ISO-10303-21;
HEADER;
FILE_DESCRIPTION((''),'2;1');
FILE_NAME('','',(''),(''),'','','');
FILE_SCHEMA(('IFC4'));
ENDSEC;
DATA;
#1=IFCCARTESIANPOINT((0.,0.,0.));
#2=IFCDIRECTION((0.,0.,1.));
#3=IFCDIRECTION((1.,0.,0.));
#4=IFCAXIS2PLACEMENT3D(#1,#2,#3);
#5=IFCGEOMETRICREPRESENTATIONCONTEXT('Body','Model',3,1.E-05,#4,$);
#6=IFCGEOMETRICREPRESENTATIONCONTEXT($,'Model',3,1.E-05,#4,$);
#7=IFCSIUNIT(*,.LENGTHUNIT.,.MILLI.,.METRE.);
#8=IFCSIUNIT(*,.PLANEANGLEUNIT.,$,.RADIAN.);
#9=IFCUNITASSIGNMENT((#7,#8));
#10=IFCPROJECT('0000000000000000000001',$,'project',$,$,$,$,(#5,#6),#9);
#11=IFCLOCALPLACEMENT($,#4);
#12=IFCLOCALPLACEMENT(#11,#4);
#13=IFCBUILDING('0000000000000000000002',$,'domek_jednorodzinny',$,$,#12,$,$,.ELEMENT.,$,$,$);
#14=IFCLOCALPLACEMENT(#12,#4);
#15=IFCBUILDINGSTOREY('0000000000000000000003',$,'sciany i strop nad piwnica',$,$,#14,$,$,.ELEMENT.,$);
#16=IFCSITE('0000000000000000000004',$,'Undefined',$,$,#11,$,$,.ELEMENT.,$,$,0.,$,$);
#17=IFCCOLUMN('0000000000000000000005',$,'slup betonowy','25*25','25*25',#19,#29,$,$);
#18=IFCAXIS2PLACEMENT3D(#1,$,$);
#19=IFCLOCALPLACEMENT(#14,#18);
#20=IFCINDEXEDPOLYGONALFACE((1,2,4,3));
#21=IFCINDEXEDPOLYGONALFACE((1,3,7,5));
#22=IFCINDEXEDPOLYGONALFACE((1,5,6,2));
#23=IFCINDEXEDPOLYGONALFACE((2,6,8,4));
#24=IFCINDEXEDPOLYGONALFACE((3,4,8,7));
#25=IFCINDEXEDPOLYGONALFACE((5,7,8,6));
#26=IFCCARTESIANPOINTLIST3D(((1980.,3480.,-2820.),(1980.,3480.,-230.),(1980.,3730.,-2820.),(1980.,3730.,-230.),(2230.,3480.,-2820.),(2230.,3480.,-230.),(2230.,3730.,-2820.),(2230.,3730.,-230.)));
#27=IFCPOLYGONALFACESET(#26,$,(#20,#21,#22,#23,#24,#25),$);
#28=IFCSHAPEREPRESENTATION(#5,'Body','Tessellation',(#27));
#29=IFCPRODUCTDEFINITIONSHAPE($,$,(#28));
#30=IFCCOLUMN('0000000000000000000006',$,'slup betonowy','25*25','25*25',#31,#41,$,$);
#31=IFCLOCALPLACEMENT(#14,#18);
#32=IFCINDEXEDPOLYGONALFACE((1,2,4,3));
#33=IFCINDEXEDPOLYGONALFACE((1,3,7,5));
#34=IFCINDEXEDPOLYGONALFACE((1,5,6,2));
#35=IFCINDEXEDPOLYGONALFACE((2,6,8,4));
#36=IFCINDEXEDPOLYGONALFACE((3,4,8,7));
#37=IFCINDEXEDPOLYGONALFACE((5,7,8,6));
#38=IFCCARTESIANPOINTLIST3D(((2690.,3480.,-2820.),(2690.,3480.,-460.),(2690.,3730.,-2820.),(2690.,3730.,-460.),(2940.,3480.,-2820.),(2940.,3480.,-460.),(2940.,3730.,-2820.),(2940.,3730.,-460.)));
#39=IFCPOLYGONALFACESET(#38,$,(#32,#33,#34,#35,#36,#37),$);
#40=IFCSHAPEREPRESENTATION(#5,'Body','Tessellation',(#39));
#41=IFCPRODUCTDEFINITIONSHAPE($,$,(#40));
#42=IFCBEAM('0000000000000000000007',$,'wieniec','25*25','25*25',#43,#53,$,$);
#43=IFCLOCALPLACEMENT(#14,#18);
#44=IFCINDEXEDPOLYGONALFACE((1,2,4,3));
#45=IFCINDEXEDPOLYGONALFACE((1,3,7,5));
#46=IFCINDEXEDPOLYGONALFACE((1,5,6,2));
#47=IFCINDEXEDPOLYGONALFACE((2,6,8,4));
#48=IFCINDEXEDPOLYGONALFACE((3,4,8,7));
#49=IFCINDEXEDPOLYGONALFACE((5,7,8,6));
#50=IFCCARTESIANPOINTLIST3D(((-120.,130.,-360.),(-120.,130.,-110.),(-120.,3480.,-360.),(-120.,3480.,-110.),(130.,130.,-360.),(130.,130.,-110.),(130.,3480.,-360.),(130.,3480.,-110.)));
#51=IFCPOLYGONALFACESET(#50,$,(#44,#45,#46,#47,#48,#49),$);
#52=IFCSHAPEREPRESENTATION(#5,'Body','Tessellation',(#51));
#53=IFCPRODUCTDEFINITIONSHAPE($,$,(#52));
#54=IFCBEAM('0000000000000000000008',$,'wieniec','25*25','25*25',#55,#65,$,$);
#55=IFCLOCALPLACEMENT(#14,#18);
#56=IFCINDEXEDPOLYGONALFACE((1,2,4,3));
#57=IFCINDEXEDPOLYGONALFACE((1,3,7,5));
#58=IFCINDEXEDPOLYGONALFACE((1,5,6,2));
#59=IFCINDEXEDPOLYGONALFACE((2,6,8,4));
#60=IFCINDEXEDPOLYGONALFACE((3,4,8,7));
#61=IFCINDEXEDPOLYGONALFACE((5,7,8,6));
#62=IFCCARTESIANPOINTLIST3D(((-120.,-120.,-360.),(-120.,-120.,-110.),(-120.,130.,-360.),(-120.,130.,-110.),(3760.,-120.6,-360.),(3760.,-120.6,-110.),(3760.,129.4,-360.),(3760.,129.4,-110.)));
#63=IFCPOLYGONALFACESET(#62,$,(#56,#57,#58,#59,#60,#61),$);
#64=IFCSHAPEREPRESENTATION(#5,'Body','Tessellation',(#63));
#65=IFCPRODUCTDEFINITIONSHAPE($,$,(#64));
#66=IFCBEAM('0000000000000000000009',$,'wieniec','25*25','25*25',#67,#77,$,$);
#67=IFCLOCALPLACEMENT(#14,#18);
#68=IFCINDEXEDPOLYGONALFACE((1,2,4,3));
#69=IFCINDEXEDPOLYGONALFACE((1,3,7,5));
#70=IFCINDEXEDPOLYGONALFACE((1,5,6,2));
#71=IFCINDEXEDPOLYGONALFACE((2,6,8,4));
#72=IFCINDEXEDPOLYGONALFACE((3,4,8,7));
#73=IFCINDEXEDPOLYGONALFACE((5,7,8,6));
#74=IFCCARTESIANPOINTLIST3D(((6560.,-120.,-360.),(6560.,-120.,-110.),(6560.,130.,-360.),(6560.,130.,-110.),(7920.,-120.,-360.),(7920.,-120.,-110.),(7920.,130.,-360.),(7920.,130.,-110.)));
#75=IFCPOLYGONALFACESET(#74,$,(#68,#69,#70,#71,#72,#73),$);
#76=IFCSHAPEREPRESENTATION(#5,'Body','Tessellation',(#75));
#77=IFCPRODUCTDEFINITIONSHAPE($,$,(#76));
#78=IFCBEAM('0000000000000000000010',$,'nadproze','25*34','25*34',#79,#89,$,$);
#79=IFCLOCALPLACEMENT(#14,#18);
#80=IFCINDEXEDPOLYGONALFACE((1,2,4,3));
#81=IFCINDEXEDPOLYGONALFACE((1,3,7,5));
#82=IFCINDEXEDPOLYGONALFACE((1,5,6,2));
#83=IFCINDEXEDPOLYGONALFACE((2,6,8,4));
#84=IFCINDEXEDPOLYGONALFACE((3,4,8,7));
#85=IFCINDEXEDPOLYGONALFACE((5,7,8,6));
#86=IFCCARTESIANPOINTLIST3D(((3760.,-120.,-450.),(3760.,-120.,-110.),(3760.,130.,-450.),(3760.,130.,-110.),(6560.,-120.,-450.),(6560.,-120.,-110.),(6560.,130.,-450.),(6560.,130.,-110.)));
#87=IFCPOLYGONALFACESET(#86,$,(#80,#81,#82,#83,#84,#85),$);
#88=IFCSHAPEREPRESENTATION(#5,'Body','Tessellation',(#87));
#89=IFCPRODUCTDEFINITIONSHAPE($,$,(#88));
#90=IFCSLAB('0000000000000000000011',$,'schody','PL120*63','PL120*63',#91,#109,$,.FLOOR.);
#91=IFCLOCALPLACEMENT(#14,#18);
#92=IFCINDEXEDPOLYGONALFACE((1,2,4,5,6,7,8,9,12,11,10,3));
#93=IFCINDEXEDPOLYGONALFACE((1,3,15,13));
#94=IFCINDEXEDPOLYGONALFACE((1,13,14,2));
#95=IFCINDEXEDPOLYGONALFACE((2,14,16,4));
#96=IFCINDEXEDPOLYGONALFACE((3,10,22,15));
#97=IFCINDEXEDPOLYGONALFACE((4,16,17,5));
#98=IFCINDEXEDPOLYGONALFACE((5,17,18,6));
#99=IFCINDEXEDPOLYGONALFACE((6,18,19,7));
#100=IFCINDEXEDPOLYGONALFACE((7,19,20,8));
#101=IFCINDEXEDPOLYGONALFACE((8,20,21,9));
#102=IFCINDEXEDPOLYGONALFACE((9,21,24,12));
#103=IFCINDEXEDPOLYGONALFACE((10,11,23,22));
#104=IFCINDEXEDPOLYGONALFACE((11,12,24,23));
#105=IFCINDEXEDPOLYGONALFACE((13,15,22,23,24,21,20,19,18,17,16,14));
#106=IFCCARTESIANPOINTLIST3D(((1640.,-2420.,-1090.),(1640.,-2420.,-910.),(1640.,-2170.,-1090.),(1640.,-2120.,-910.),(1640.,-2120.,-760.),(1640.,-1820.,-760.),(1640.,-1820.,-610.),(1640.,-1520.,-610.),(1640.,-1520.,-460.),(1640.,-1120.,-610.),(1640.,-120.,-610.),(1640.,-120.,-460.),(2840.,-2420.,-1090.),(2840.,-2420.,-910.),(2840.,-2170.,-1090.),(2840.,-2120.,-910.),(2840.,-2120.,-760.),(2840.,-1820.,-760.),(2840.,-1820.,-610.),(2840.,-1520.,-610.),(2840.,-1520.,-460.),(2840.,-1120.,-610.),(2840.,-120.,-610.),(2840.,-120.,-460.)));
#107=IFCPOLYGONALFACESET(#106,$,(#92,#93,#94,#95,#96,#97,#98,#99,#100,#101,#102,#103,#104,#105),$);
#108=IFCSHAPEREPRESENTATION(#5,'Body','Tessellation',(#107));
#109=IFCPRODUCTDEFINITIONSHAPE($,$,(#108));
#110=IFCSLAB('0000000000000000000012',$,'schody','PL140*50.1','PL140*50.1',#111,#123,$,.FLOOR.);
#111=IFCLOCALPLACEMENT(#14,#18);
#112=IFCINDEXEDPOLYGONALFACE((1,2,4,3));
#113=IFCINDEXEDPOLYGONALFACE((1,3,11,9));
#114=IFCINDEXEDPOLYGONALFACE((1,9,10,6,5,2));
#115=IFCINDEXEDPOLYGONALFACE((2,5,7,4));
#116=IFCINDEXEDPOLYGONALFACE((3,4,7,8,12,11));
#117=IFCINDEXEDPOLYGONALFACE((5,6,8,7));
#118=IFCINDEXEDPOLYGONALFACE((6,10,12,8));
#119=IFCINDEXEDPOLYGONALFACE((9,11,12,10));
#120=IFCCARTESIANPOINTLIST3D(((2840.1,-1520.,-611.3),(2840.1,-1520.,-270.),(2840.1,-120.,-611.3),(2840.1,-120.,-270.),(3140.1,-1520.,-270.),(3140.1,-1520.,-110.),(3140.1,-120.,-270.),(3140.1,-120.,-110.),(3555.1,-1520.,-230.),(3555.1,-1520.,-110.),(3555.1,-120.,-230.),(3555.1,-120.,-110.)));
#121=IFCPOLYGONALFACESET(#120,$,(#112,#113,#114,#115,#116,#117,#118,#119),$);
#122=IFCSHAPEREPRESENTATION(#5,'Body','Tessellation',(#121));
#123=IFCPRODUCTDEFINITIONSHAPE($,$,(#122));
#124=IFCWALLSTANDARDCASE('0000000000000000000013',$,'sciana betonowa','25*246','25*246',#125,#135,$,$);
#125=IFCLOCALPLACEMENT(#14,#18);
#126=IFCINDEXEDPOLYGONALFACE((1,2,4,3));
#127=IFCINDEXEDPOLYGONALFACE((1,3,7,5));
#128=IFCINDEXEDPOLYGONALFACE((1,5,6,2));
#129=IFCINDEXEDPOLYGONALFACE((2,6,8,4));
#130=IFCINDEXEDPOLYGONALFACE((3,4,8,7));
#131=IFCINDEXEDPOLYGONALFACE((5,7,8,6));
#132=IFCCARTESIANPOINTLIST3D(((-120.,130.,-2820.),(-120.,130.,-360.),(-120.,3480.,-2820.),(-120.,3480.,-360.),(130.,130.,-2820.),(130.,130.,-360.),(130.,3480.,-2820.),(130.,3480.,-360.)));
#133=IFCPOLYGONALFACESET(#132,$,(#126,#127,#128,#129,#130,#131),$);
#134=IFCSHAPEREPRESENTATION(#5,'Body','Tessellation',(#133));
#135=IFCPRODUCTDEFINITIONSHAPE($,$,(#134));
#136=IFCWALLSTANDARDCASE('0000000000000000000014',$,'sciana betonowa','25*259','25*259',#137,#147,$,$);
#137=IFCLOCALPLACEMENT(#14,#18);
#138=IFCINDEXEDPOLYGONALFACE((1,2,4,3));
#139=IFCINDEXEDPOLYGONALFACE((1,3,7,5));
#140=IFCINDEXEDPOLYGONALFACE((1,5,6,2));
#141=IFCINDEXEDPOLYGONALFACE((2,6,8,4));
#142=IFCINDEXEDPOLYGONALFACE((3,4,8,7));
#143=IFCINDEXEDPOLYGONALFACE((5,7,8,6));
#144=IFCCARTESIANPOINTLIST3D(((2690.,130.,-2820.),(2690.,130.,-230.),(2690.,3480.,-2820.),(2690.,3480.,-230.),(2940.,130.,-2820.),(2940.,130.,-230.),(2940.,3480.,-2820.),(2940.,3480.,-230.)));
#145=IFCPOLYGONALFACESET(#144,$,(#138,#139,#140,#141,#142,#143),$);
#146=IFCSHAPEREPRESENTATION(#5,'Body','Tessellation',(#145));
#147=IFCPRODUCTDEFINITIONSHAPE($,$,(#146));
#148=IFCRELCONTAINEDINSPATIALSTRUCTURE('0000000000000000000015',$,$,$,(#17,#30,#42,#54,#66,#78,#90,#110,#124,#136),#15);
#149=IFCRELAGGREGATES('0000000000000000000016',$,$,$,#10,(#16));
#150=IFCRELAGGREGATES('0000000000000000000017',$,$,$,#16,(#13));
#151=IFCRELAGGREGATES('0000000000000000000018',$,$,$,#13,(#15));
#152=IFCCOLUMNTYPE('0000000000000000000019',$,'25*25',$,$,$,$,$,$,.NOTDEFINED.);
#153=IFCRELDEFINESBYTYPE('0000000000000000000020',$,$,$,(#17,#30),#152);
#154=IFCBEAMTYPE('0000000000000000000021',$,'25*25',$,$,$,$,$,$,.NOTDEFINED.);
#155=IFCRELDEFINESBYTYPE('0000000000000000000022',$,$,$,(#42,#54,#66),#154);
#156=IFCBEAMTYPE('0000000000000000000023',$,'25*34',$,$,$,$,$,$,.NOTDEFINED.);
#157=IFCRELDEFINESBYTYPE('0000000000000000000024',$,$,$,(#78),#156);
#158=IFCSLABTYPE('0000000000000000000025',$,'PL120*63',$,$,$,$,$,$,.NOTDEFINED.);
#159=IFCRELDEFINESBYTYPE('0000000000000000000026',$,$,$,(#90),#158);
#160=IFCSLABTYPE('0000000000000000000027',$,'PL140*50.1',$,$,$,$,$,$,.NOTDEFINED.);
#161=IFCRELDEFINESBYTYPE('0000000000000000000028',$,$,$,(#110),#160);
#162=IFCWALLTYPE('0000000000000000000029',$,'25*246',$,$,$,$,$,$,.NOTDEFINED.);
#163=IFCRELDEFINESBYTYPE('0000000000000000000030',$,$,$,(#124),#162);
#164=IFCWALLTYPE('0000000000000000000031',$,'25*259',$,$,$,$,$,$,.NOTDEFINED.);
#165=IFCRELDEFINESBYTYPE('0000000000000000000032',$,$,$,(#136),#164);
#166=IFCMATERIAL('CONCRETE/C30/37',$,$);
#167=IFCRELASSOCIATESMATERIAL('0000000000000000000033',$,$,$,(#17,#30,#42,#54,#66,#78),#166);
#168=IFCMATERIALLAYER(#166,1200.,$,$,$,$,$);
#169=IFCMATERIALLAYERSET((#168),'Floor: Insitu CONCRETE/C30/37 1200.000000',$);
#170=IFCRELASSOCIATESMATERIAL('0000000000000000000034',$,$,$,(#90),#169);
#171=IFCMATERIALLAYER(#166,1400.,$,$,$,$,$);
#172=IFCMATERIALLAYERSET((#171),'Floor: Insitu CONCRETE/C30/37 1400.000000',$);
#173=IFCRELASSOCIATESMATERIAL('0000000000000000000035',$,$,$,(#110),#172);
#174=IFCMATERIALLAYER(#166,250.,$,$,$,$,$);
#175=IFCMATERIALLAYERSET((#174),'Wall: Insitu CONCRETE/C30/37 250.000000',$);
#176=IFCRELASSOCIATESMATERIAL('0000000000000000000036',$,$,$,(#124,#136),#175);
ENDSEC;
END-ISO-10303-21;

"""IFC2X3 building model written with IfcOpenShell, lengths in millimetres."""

from ifc_helpers import new_model, si_unit, frame, frame_2d, origin_with_axes, origin_2d_with_axis, place, context, project, spatial, polyline, rectangle, outline, extrude, material, layer, layer_set, layer_usage, type_object, element, save


model = new_model("IFC2X3")

# Units and contexts
model_context_1 = context("Model", 3, precision=1e-05, world=origin_with_axes(), identifier="Body")
model_context_2 = context("Model", 3, precision=1e-05, world=origin_with_axes())
ifc_project = project(units=[si_unit("LENGTHUNIT", "METRE", prefix="MILLI"), si_unit("PLANEANGLEUNIT", "RADIAN")], contexts=[model_context_1, model_context_2])

# Site, building, storey
site_placement = place(None, origin_with_axes())
site = spatial("IfcSite", under=ifc_project, at=site_placement, Name="Undefined", CompositionType="ELEMENT", RefElevation=0.0)
building_placement = place(site_placement, origin_with_axes())
building = spatial("IfcBuilding", under=site, at=building_placement, Name="domek_jednorodzinny", CompositionType="ELEMENT")
storey_placement = place(building_placement, origin_with_axes())
storey = spatial("IfcBuildingStorey", under=building, at=storey_placement, Name="sciany i strop nad piwnica", CompositionType="ELEMENT")

# Columns
ifc_material_1 = material(Name="CONCRETE/C30/37")
column_type = type_object("IfcColumnType", Name="25*25", PredefinedType="NOTDEFINED")
column_1_placement = place(storey_placement, frame((2105.0, 3605.0, -2820.0), z_axis=(0.0, 0.0, 1.0), x_axis=(1.0, 0.0, 0.0)))
element("IfcColumn", 1, at=column_1_placement, inside=storey, type_object=column_type, material=ifc_material_1, Name="slup betonowy", Description="25*25", ObjectType="25*25", context=model_context_1, shape_type="SweptSolid", body=[
    extrude(rectangle(XDim=250.0, YDim=250.0, at=origin_2d_with_axis()), frame((0.0, 0.0, 2590.0), z_axis=(0.000001, 0.000001, -1.0), x_axis=(-1.0, 0.0, 0.0)), (0.0, 0.0, 1.0), 2590.0),
])
column_2_placement = place(storey_placement, frame((2815.0, 3605.0, -2820.0), z_axis=(0.0, 0.0, 1.0), x_axis=(1.0, 0.0, 0.0)))
element("IfcColumn", 2, at=column_2_placement, inside=storey, type_object=column_type, material=ifc_material_1, Name="slup betonowy", Description="25*25", ObjectType="25*25", context=model_context_1, shape_type="SweptSolid", body=[
    extrude(rectangle(XDim=250.0, YDim=250.0, at=origin_2d_with_axis()), frame((0.0, 0.0, 2360.0), z_axis=(0.000001, 0.000001, -1.0), x_axis=(-1.0, 0.0, 0.0)), (0.0, 0.0, 1.0), 2360.0),
])

# Beams
beam_type_1 = type_object("IfcBeamType", Name="25*25", PredefinedType="NOTDEFINED")
beam_1_placement = place(storey_placement, frame((5.0, 130.0, -235.0), z_axis=(0.0, 0.0, 1.0), x_axis=(0.0, 1.0, 0.0)))
element("IfcBeam", 3, at=beam_1_placement, inside=storey, type_object=beam_type_1, material=ifc_material_1, Name="wieniec", Description="25*25", ObjectType="25*25", context=model_context_1, shape_type="SweptSolid", body=[
    extrude(rectangle(XDim=250.0, YDim=250.0, at=origin_2d_with_axis()), frame((3350.0, 0.0, 0.0), z_axis=(-1.0, 0.0, 0.0), x_axis=(0.0, -1.0, 0.0)), (0.0, 0.0, 1.0), 3350.0),
])
beam_2_placement = place(storey_placement, frame((-120.0, 5.0, -235.0), z_axis=(0.0, 0.0, 1.0), x_axis=(1.0, -0.000149, 0.0)))
element("IfcBeam", 4, at=beam_2_placement, inside=storey, type_object=beam_type_1, material=ifc_material_1, Name="wieniec", Description="25*25", ObjectType="25*25", context=model_context_1, shape_type="SweptSolid", body=[
    extrude(rectangle(XDim=250.0, YDim=250.0, at=origin_2d_with_axis()), frame((3880.0, 0.0, 0.0), z_axis=(-1.0, 0.0, 0.0), x_axis=(0.0, -1.0, 0.0)), (0.0, 0.0, 1.0), 3880.0),
])
beam_3_placement = place(storey_placement, frame((6560.0, 5.0, -235.0), z_axis=(0.0, 0.0, 1.0), x_axis=(1.0, 0.0, 0.0)))
element("IfcBeam", 5, at=beam_3_placement, inside=storey, type_object=beam_type_1, material=ifc_material_1, Name="wieniec", Description="25*25", ObjectType="25*25", context=model_context_1, shape_type="SweptSolid", body=[
    extrude(rectangle(XDim=250.0, YDim=250.0, at=origin_2d_with_axis()), frame((1360.0, 0.0, 0.0), z_axis=(-1.0, 0.0, 0.0), x_axis=(0.0, -1.0, 0.0)), (0.0, 0.0, 1.0), 1360.0),
])
beam_type_2 = type_object("IfcBeamType", Name="25*34", PredefinedType="NOTDEFINED")
beam_4_placement = place(storey_placement, frame((3760.0, 5.0, -280.0), z_axis=(0.0, 0.0, 1.0), x_axis=(1.0, 0.0, 0.0)))
element("IfcBeam", 6, at=beam_4_placement, inside=storey, type_object=beam_type_2, material=ifc_material_1, Name="nadproze", Description="25*34", ObjectType="25*34", context=model_context_1, shape_type="SweptSolid", body=[
    extrude(rectangle(XDim=250.0, YDim=340.0, at=origin_2d_with_axis()), frame((2800.0, 0.0, 0.0), z_axis=(-1.0, 0.0, 0.0), x_axis=(0.0, -1.0, 0.0)), (0.0, 0.0, 1.0), 2800.0),
])

# Slabs, openings
ifc_layer_1 = layer(ifc_material_1, 1200.0)
ifc_layer_set_1 = layer_set([ifc_layer_1], Name="Floor: Insitu CONCRETE/C30/37 1200.000000")
ifc_layer_usage_1 = layer_usage(ifc_layer_set_1, "AXIS3", "POSITIVE", -600.0)
slab_type_1 = type_object("IfcSlabType", Name="PL120*63", PredefinedType="NOTDEFINED")
slab_1_placement = place(storey_placement, frame((2240.0, -2420.0, -910.0), z_axis=(1.0, 0.0, 0.0), x_axis=(0.000001, 0.000001, -1.0)))
slab_1 = element("IfcSlab", 7, at=slab_1_placement, inside=storey, type_object=slab_type_1, material=ifc_layer_usage_1, Name="schody", Description="PL120*63", ObjectType="PL120*63", PredefinedType="FLOOR", context=model_context_1, shape_type="SweptSolid", body=[
    extrude(outline(polyline([(0.0, 0.0), (180.0, 0.0), (180.0, 250.0), (-300.0, 1300.0), (-300.0, 2300.0), (-450.0, 2300.0), (-450.0, 900.0), (0.0, 0.0)])), frame((0.0, 0.0, -600.0), z_axis=(0.0, 0.0, 1.0), x_axis=(1.0, 0.0, 0.0)), (0.0, 0.0, 1.0), 1200.0),
])
opening_1_placement = place(storey_placement, frame((2240.0, -2420.0, -910.0), z_axis=(1.0, 0.0, 0.0), x_axis=(0.000001, 0.000001, -1.0)))
element("IfcOpeningElement", 8, at=opening_1_placement, cuts=slab_1, ObjectType="Recess", context=model_context_1, shape_type="SweptSolid", body=[
    extrude(outline(polyline([(0.0, 0.0), (200.0, 0.0), (200.0, 300.0), (0.0, 300.0), (0.0, 0.0)])), frame((-50.0, -300.0, -610.0), z_axis=(0.0, 0.0, 1.0), x_axis=(1.0, 0.0, 0.0)), (0.0, 0.0, 1.0), 1220.0),
])
opening_2_placement = place(storey_placement, frame((2240.0, -2420.0, -910.0), z_axis=(1.0, 0.0, 0.0), x_axis=(0.000001, 0.000001, -1.0)))
element("IfcOpeningElement", 9, at=opening_2_placement, cuts=slab_1, ObjectType="Recess", context=model_context_1, shape_type="SweptSolid", body=[
    extrude(outline(polyline([(0.0, 0.0), (200.0, 0.0), (200.0, 300.0), (0.0, 300.0), (0.0, 0.0)])), frame((-200.0, 0.0, -610.0), z_axis=(0.0, 0.0, 1.0), x_axis=(1.0, 0.0, 0.0)), (0.0, 0.0, 1.0), 1220.0),
])
opening_3_placement = place(storey_placement, frame((2240.0, -2420.0, -910.0), z_axis=(1.0, 0.0, 0.0), x_axis=(0.000001, 0.000001, -1.0)))
element("IfcOpeningElement", 10, at=opening_3_placement, cuts=slab_1, ObjectType="Recess", context=model_context_1, shape_type="SweptSolid", body=[
    extrude(outline(polyline([(0.0, 0.0), (200.0, 0.0), (200.0, 300.0), (0.0, 300.0), (0.0, 0.0)])), frame((-350.0, 300.0, -610.0), z_axis=(0.0, 0.0, 1.0), x_axis=(1.0, 0.0, 0.0)), (0.0, 0.0, 1.0), 1220.0),
])
opening_4_placement = place(storey_placement, frame((2240.0, -2420.0, -910.0), z_axis=(1.0, 0.0, 0.0), x_axis=(0.000001, 0.000001, -1.0)))
element("IfcOpeningElement", 11, at=opening_4_placement, cuts=slab_1, ObjectType="Recess", context=model_context_1, shape_type="SweptSolid", body=[
    extrude(outline(polyline([(0.0, 0.0), (200.0, 0.0), (200.0, 300.0), (0.0, 300.0), (0.0, 0.0)])), frame((-500.0, 600.0, -610.0), z_axis=(0.0, 0.0, 1.0), x_axis=(1.0, 0.0, 0.0)), (0.0, 0.0, 1.0), 1220.0),
])
ifc_layer_2 = layer(ifc_material_1, 1400.0)
ifc_layer_set_2 = layer_set([ifc_layer_2], Name="Floor: Insitu CONCRETE/C30/37 1400.000000")
ifc_layer_usage_2 = layer_usage(ifc_layer_set_2, "AXIS3", "POSITIVE", -700.0)
slab_type_2 = type_object("IfcSlabType", Name="PL140*50.1", PredefinedType="NOTDEFINED")
slab_2_placement = place(storey_placement, frame((2840.1, -820.0, -270.0), z_axis=(0.0, -1.0, 0.0), x_axis=(0.000001, 0.000001, -1.0)))
slab_2 = element("IfcSlab", 12, at=slab_2_placement, inside=storey, type_object=slab_type_2, material=ifc_layer_usage_2, Name="schody", Description="PL140*50.1", ObjectType="PL140*50.1", PredefinedType="FLOOR", context=model_context_1, shape_type="SweptSolid", body=[
    extrude(outline(polyline([(0.0, 0.0), (341.3, 0.0), (-40.0, 715.0), (-160.0, 715.0), (-160.0, 300.0), (0.0, 0.0)])), frame((0.0, 0.0, -700.0), z_axis=(0.0, 0.0, 1.0), x_axis=(1.0, 0.0, 0.0)), (0.0, 0.0, 1.0), 1400.0),
])
opening_5_placement = place(storey_placement, frame((2840.1, -820.0, -270.0), z_axis=(0.0, -1.0, 0.0), x_axis=(0.000001, 0.000001, -1.0)))
element("IfcOpeningElement", 13, at=opening_5_placement, cuts=slab_2, ObjectType="Recess", context=model_context_1, shape_type="SweptSolid", body=[
    extrude(outline(polyline([(0.0, 0.0), (210.0, 0.0), (210.0, 300.0), (0.0, 300.0), (0.0, 0.0)])), frame((-50.0, -300.0, -710.0), z_axis=(0.0, 0.0, 1.0), x_axis=(1.0, 0.0, 0.0)), (0.0, 0.0, 1.0), 1420.0),
])
opening_6_placement = place(storey_placement, frame((2840.1, -820.0, -270.0), z_axis=(0.0, -1.0, 0.0), x_axis=(0.000001, 0.000001, -1.0)))
element("IfcOpeningElement", 14, at=opening_6_placement, cuts=slab_2, ObjectType="Recess", context=model_context_1, shape_type="SweptSolid", body=[
    extrude(outline(polyline([(0.0, 0.0), (210.0, 0.0), (210.0, 300.0), (0.0, 300.0), (0.0, 0.0)])), frame((-210.0, 0.0, -710.0), z_axis=(0.0, 0.0, 1.0), x_axis=(1.0, 0.0, 0.0)), (0.0, 0.0, 1.0), 1420.0),
])

# Wall
ifc_layer_3 = layer(ifc_material_1, 250.0)
ifc_layer_set_3 = layer_set([ifc_layer_3], Name="Wall: Insitu CONCRETE/C30/37 250.000000")
ifc_layer_usage_3 = layer_usage(ifc_layer_set_3, "AXIS2", "POSITIVE", -125.0)
wall_type_1 = type_object("IfcWallType", Name="25*246", PredefinedType="NOTDEFINED")
wall_1_placement = place(storey_placement, frame((5.0, 130.0, -2820.0), z_axis=(0.0, 0.0, 1.0), x_axis=(0.0, 1.0, 0.0)))
element("IfcWallStandardCase", 15, at=wall_1_placement, inside=storey, type_object=wall_type_1, material=ifc_layer_usage_3, Name="sciana betonowa", Description="25*246", ObjectType="25*246", context=model_context_1, shape_type="SweptSolid", body=[
    extrude(rectangle(XDim=3350.0, YDim=250.0, at=frame_2d((0.0, 1675.0), x_axis=(0.0, -1.0))), frame((0.0, 0.0, 0.0), z_axis=(0.0, 0.0, 1.0), x_axis=(0.0, -1.0, 0.0)), (0.0, 0.0, 1.0), 2460.0),
])

# Wall
ifc_layer_usage_4 = layer_usage(ifc_layer_set_3, "AXIS2", "POSITIVE", -125.0)
wall_type_2 = type_object("IfcWallType", Name="25*259", PredefinedType="NOTDEFINED")
wall_2_placement = place(storey_placement, frame((2815.0, 130.0, -2820.0), z_axis=(0.0, 0.0, 1.0), x_axis=(0.0, 1.0, 0.0)))
element("IfcWallStandardCase", 16, at=wall_2_placement, inside=storey, type_object=wall_type_2, material=ifc_layer_usage_4, Name="sciana betonowa", Description="25*259", ObjectType="25*259", context=model_context_1, shape_type="SweptSolid", body=[
    extrude(rectangle(XDim=3350.0, YDim=250.0, at=frame_2d((0.0, 1675.0), x_axis=(0.0, -1.0))), frame((0.0, 0.0, 0.0), z_axis=(0.0, 0.0, 1.0), x_axis=(0.0, -1.0, 0.0)), (0.0, 0.0, 1.0), 2590.0),
])

save(model, "model.ifc")
